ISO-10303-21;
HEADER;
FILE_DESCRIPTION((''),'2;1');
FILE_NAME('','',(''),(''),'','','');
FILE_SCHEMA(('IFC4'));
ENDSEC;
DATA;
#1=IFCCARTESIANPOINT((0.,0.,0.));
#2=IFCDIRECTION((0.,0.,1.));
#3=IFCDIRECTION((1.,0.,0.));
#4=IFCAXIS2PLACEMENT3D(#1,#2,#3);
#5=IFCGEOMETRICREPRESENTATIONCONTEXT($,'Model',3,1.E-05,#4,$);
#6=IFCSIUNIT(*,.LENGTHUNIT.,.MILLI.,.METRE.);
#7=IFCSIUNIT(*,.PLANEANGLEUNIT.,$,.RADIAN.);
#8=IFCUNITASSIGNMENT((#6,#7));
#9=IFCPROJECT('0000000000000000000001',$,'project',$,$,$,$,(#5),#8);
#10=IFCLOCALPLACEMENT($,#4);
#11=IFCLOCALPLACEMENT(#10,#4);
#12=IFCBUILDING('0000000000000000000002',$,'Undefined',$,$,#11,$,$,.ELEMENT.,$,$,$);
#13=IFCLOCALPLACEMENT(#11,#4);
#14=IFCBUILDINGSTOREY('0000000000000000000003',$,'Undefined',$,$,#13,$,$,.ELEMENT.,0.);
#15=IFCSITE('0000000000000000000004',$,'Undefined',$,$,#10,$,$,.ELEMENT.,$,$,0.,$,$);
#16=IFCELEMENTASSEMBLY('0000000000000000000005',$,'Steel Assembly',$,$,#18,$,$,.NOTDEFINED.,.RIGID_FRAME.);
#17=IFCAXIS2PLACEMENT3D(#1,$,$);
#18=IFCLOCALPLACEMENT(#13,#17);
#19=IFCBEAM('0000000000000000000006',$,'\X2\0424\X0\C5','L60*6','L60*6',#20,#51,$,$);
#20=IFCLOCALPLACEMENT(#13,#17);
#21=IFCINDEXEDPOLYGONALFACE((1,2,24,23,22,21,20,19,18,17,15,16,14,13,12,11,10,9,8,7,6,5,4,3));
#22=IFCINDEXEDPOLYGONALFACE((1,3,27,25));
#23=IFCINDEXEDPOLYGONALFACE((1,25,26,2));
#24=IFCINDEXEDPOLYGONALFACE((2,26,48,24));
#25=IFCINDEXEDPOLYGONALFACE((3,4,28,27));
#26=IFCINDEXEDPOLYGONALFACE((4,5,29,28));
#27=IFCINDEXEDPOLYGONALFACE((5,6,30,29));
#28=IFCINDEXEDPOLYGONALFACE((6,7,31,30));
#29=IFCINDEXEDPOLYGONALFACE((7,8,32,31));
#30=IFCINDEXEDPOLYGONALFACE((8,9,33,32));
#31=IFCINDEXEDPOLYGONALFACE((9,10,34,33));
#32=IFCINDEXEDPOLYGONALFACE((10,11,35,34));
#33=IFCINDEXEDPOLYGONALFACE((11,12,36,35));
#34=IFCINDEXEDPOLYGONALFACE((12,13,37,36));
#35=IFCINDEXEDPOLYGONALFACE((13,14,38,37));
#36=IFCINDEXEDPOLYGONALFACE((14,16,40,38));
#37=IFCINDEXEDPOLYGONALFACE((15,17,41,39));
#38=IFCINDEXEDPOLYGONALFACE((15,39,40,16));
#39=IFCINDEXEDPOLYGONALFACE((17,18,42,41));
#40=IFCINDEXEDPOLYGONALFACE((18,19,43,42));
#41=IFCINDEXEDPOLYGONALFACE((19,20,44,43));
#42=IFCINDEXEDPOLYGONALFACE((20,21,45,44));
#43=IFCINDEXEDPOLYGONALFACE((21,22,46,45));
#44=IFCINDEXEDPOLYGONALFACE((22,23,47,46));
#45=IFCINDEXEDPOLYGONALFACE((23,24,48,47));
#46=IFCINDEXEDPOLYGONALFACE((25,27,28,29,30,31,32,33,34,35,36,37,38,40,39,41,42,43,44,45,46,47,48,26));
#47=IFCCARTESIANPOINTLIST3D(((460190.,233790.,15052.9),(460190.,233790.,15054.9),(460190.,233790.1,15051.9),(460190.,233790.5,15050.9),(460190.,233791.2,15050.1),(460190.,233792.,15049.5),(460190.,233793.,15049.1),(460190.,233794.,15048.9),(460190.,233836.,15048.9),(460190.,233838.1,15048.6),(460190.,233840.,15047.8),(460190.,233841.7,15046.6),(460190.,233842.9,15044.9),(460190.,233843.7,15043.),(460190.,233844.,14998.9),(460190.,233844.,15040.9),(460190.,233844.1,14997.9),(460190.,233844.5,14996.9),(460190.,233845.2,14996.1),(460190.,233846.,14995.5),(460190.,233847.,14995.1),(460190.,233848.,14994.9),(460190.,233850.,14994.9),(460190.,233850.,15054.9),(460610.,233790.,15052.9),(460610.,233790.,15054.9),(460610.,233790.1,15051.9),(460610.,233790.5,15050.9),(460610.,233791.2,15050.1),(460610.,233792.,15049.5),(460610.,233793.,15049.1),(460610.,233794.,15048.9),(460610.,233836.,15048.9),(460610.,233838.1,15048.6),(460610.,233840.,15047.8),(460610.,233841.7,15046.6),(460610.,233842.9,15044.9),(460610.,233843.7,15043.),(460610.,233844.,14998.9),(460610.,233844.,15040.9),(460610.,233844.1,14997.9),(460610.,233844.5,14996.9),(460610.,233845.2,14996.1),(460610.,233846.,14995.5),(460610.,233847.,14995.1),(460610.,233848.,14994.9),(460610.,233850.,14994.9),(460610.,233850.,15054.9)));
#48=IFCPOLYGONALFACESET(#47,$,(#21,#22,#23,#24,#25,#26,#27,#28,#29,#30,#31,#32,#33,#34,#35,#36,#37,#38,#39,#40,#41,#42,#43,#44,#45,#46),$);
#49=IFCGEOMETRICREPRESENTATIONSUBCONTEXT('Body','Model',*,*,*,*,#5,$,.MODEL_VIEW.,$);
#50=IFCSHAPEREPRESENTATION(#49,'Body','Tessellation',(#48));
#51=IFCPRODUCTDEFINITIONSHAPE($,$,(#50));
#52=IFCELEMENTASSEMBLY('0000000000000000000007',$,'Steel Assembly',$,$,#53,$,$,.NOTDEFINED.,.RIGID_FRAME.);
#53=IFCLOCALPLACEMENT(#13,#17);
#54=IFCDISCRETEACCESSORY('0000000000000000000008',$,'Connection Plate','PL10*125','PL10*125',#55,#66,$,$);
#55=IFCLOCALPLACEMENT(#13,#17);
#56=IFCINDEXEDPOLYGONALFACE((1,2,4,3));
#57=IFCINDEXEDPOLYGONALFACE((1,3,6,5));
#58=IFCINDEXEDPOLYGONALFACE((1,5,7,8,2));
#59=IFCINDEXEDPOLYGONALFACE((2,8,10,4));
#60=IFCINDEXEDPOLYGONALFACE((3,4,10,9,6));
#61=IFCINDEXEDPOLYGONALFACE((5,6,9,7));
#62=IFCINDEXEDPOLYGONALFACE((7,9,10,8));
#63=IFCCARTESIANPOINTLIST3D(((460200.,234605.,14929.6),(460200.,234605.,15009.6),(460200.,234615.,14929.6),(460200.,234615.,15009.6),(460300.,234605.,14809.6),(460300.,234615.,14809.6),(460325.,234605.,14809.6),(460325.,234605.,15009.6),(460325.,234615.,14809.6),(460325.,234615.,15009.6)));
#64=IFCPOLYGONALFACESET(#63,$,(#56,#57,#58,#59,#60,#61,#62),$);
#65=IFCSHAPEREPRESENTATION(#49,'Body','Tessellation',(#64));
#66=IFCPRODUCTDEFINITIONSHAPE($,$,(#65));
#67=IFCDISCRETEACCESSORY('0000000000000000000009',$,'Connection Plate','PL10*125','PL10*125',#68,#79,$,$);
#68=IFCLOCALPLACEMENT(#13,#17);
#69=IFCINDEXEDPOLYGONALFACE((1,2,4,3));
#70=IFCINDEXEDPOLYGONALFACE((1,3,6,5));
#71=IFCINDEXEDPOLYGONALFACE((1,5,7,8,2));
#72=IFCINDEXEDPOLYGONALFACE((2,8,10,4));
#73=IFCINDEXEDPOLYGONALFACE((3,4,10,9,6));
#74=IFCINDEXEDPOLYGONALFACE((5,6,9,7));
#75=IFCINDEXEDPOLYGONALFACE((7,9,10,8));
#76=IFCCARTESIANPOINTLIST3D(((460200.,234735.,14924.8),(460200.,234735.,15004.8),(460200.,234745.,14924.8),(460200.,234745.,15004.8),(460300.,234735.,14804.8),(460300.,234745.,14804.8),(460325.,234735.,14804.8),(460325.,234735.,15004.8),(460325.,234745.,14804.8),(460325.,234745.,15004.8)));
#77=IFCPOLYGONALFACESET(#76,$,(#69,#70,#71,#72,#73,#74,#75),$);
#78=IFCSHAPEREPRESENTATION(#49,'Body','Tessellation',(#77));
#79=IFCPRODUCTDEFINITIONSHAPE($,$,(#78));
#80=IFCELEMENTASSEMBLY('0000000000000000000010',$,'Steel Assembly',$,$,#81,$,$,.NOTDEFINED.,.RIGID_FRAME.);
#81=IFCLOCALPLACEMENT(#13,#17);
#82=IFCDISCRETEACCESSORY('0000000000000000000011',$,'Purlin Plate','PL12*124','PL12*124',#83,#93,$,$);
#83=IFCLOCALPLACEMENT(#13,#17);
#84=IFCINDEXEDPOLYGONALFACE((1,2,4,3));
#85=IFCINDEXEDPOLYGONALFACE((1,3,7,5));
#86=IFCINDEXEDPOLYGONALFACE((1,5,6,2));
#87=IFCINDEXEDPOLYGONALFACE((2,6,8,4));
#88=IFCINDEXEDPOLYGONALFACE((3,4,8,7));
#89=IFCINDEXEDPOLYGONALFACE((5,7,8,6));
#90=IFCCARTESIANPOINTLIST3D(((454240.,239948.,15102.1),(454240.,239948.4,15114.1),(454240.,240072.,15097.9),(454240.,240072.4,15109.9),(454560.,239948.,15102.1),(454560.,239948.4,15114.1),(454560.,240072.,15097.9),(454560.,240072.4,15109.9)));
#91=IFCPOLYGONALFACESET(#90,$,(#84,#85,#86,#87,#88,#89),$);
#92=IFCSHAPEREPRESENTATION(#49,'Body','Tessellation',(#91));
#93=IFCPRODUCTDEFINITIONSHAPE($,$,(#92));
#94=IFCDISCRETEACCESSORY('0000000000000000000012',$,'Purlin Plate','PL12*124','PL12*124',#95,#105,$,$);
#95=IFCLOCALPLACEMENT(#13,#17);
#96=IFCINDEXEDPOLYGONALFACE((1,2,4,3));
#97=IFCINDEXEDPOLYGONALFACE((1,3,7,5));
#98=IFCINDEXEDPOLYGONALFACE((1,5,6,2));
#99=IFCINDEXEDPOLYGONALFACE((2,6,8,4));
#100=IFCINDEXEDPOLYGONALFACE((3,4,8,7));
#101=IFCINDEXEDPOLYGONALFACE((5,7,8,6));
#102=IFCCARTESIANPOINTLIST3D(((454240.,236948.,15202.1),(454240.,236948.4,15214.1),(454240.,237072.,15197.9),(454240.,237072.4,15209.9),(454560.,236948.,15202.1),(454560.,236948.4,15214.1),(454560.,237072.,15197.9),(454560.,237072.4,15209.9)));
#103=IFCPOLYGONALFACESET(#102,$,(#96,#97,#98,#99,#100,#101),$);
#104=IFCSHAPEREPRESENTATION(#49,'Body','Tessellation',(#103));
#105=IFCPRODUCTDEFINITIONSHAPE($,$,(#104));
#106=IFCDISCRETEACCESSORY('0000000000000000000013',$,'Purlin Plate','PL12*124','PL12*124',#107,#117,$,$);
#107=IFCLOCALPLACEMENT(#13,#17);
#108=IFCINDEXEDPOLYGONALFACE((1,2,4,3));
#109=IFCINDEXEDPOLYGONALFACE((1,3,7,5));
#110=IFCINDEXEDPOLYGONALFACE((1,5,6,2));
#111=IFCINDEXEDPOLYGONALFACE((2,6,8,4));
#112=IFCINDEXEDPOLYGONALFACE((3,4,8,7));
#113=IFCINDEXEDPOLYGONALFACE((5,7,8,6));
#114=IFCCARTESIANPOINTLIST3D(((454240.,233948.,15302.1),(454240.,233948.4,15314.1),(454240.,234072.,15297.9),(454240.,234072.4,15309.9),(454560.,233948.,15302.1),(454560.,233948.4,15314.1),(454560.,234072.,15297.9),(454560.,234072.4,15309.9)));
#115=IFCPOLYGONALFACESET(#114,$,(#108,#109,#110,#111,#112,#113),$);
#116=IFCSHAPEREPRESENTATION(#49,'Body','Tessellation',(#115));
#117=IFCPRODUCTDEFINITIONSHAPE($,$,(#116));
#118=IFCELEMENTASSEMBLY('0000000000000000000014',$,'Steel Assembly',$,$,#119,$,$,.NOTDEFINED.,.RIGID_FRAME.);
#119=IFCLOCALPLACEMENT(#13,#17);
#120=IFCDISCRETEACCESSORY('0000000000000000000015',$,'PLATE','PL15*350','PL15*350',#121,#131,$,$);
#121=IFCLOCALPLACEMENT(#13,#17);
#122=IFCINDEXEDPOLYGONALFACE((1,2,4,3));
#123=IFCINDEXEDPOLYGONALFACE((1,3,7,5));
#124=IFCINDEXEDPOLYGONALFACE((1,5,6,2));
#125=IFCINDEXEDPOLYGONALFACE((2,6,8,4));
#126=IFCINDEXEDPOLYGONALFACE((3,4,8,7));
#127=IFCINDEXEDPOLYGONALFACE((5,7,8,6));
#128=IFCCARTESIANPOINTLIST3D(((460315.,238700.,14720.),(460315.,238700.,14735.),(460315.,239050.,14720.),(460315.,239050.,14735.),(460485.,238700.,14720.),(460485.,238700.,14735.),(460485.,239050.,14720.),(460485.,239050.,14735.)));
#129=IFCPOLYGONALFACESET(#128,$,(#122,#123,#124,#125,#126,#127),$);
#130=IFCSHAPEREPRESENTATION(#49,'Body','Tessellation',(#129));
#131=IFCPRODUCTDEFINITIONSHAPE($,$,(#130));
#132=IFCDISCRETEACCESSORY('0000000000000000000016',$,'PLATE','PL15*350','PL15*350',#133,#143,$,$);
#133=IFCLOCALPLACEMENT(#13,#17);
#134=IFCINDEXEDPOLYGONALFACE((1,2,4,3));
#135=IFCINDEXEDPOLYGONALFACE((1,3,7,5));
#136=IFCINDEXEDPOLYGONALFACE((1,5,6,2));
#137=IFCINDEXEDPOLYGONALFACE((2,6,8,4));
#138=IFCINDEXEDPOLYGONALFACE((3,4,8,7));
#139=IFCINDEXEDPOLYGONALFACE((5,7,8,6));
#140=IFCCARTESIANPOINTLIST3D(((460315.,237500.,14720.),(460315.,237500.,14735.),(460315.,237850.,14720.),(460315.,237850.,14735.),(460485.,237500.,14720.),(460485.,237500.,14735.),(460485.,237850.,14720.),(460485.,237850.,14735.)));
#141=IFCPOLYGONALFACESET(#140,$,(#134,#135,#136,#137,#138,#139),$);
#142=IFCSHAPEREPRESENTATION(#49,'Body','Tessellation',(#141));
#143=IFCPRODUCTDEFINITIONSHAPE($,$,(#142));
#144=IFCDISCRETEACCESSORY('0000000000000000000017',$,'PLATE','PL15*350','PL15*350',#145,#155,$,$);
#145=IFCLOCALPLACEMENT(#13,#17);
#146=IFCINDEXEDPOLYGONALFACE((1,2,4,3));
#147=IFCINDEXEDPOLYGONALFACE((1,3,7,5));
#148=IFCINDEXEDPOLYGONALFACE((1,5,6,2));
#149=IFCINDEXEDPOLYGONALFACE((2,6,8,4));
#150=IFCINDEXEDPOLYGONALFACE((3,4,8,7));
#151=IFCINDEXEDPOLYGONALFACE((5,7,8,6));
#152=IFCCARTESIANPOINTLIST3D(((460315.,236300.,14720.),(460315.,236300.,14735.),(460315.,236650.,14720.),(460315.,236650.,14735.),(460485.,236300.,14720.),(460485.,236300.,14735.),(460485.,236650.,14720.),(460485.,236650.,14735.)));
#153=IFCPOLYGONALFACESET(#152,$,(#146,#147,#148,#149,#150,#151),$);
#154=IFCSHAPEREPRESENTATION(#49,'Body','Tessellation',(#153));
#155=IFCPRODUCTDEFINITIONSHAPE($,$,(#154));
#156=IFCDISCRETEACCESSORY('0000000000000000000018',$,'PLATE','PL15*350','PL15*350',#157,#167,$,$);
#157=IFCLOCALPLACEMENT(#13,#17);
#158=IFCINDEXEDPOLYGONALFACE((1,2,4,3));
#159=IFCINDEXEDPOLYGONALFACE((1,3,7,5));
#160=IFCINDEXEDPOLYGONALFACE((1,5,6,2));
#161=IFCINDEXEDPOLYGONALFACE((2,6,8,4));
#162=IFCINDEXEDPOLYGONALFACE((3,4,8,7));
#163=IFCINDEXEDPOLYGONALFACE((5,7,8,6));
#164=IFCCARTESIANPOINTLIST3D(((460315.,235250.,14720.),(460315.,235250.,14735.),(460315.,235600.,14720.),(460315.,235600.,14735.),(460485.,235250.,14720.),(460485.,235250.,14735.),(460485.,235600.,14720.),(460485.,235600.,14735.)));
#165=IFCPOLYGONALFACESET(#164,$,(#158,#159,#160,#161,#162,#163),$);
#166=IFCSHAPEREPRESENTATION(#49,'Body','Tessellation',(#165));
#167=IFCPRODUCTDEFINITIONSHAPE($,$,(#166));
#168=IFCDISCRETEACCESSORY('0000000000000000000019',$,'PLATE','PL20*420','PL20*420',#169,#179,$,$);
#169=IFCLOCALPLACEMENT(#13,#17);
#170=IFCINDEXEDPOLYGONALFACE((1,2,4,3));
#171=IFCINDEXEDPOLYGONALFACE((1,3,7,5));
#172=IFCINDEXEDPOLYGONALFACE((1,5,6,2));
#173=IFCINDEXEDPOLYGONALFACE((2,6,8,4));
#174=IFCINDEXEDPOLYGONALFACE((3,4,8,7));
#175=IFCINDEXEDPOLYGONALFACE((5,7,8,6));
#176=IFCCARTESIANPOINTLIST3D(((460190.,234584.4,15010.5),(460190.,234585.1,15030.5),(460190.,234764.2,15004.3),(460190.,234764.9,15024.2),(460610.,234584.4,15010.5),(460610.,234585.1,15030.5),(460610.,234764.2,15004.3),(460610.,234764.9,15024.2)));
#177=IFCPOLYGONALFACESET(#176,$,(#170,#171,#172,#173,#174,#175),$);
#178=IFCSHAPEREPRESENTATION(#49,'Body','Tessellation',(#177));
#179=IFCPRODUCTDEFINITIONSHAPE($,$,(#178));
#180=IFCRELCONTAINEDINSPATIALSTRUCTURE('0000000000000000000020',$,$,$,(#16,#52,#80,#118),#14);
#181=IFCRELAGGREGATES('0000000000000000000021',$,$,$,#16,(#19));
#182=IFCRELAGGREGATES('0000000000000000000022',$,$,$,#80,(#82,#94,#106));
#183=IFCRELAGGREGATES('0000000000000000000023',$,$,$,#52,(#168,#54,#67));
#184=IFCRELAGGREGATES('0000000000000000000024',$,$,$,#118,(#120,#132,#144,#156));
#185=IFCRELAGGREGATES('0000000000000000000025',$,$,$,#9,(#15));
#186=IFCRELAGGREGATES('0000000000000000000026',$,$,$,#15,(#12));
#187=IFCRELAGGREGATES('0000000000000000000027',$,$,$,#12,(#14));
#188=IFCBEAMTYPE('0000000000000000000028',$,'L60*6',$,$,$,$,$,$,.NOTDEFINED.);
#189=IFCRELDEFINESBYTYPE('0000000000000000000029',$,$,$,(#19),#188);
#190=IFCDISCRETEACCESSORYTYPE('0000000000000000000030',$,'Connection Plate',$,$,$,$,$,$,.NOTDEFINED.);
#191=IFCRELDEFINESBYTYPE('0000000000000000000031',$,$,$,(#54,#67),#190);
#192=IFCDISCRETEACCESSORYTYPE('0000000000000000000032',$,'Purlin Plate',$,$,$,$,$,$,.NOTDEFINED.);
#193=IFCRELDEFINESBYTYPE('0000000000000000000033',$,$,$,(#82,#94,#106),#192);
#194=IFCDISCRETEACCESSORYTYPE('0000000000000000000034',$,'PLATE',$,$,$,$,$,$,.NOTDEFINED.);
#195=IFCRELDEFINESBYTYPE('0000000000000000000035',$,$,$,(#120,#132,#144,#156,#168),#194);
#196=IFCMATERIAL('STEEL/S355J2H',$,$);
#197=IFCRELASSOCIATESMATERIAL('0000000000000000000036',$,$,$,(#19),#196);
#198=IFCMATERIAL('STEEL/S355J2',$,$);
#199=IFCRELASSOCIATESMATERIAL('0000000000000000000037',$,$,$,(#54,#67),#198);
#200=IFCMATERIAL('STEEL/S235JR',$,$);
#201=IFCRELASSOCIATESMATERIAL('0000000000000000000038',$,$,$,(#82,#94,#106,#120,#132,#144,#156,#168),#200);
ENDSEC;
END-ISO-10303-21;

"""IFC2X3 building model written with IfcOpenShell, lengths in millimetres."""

from ifc_helpers import new_model, si_unit, frame, origin_with_axes, origin_2d_with_axis, place, context, subcontext, project, spatial, polyline, l_section, outline, extrude, material, type_object, element, aggregate, save


model = new_model("IFC2X3")

# Units and contexts
model_context = context("Model", 3, precision=1e-05, world=origin_with_axes())
body_context = subcontext(model_context, "Body", "Model", "MODEL_VIEW")
ifc_project = project(units=[si_unit("LENGTHUNIT", "METRE", prefix="MILLI"), si_unit("PLANEANGLEUNIT", "RADIAN")], contexts=[model_context])

# Site, building, storey
site_placement = place(None, origin_with_axes())
site = spatial("IfcSite", under=ifc_project, at=site_placement, Name="Undefined", CompositionType="ELEMENT", RefElevation=0.0)
building_placement = place(site_placement, origin_with_axes())
building = spatial("IfcBuilding", under=site, at=building_placement, Name="Undefined", CompositionType="ELEMENT")
storey_placement = place(building_placement, origin_with_axes())
storey = spatial("IfcBuildingStorey", under=building, at=storey_placement, Name="Undefined", CompositionType="ELEMENT", Elevation=0.0)

# Element assembly, beam
ifc_material_1 = material(Name="STEEL/S355J2H")
beam_type_1 = type_object("IfcBeamType", Name="L60*6", PredefinedType="NOTDEFINED")
assembly_1_placement = place(storey_placement, origin_with_axes())
assembly_1 = element("IfcElementAssembly", 1, at=assembly_1_placement, inside=storey, Name="Steel Assembly", AssemblyPlace="NOTDEFINED", PredefinedType="RIGID_FRAME")
beam_1_placement = place(assembly_1_placement, frame((460190.0, 233820.0, 15024.9), z_axis=(0.0, -1.0, 0.0), x_axis=(1.0, 0.0, 0.0)))
beam_1 = element("IfcBeam", 2, at=beam_1_placement, type_object=beam_type_1, material=ifc_material_1, Name="ФC5", Description="L60*6", ObjectType="L60*6", context=body_context, shape_type="SweptSolid", body=[
    extrude(l_section(Depth=60.0, Width=60.0, Thickness=6.0, FilletRadius=8.0, EdgeRadius=4.0, at=origin_2d_with_axis()), frame((420.0, 0.0, 0.0), z_axis=(-1.0, 0.0, 0.0), x_axis=(0.0, -1.0, 0.0)), (0.0, 0.0, 1.0), 420.0),
])
aggregate(assembly_1, [beam_1])

# Element assemblies, discrete accessories
assembly_2_placement = place(storey_placement, origin_with_axes())
assembly_2 = element("IfcElementAssembly", 3, at=assembly_2_placement, inside=storey, Name="Steel Assembly", AssemblyPlace="NOTDEFINED", PredefinedType="RIGID_FRAME")
ifc_material_2 = material(Name="STEEL/S355J2")
discrete_accessory_type_1 = type_object("IfcDiscreteAccessoryType", Name="Connection Plate")
discrete_accessory_1_placement = place(assembly_2_placement, frame((460200.0, 234610.0, 15009.6), z_axis=(0.0, 1.0, 0.0), x_axis=(1.0, 0.0, 0.0)))
discrete_accessory_1 = element("IfcDiscreteAccessory", 4, at=discrete_accessory_1_placement, type_object=discrete_accessory_type_1, material=ifc_material_2, Name="Connection Plate", Description="PL10*125", ObjectType="PL10*125", context=body_context, shape_type="SweptSolid", body=[
    extrude(outline(polyline([(0.0, 0.0), (125.0, 0.0), (125.0, 200.0), (100.0, 200.0), (0.0, 80.0), (0.0, 0.0)])), frame((0.0, 0.0, -5.0), z_axis=(0.0, 0.0, 1.0), x_axis=(1.0, 0.0, 0.0)), (0.0, 0.0, 1.0), 10.0),
])
discrete_accessory_2_placement = place(assembly_2_placement, frame((460200.0, 234740.0, 15004.8), z_axis=(0.0, 1.0, 0.0), x_axis=(1.0, 0.0, 0.0)))
discrete_accessory_2 = element("IfcDiscreteAccessory", 5, at=discrete_accessory_2_placement, type_object=discrete_accessory_type_1, material=ifc_material_2, Name="Connection Plate", Description="PL10*125", ObjectType="PL10*125", context=body_context, shape_type="SweptSolid", body=[
    extrude(outline(polyline([(0.0, 0.0), (125.0, 0.0), (125.0, 200.0), (100.0, 200.0), (0.0, 80.0), (0.0, 0.0)])), frame((0.0, 0.0, -5.0), z_axis=(0.0, 0.0, 1.0), x_axis=(1.0, 0.0, 0.0)), (0.0, 0.0, 1.0), 10.0),
])
assembly_3_placement = place(storey_placement, origin_with_axes())
assembly_3 = element("IfcElementAssembly", 6, at=assembly_3_placement, inside=storey, Name="Steel Assembly", AssemblyPlace="NOTDEFINED", PredefinedType="RIGID_FRAME")
ifc_material_3 = material(Name="STEEL/S235JR")
discrete_accessory_type_2 = type_object("IfcDiscreteAccessoryType", Name="Purlin Plate")
discrete_accessory_3_placement = place(assembly_3_placement, frame((454560.0, 240072.2, 15103.9), z_axis=(0.0, -0.033315, -0.999445), x_axis=(0.0, -0.999445, 0.033315)))
discrete_accessory_3 = element("IfcDiscreteAccessory", 7, at=discrete_accessory_3_placement, type_object=discrete_accessory_type_2, material=ifc_material_3, Name="Purlin Plate", Description="PL12*124", ObjectType="PL12*124", context=body_context, shape_type="SweptSolid", body=[
    extrude(outline(polyline([(0.0, 0.0), (124.0, 0.0), (124.0, 320.0), (0.0, 320.0), (0.0, 0.0)])), frame((0.0, 0.0, -6.0), z_axis=(0.0, 0.0, 1.0), x_axis=(1.0, 0.0, 0.0)), (0.0, 0.0, 1.0), 12.0),
])
discrete_accessory_4_placement = place(assembly_3_placement, frame((454560.0, 237072.2, 15203.9), z_axis=(0.0, -0.033315, -0.999445), x_axis=(0.0, -0.999445, 0.033315)))
discrete_accessory_4 = element("IfcDiscreteAccessory", 8, at=discrete_accessory_4_placement, type_object=discrete_accessory_type_2, material=ifc_material_3, Name="Purlin Plate", Description="PL12*124", ObjectType="PL12*124", context=body_context, shape_type="SweptSolid", body=[
    extrude(outline(polyline([(0.0, 0.0), (124.0, 0.0), (124.0, 320.0), (0.0, 320.0), (0.0, 0.0)])), frame((0.0, 0.0, -6.0), z_axis=(0.0, 0.0, 1.0), x_axis=(1.0, 0.0, 0.0)), (0.0, 0.0, 1.0), 12.0),
])
discrete_accessory_5_placement = place(assembly_3_placement, frame((454560.0, 234072.2, 15303.9), z_axis=(0.0, -0.033315, -0.999445), x_axis=(0.0, -0.999445, 0.033315)))
discrete_accessory_5 = element("IfcDiscreteAccessory", 9, at=discrete_accessory_5_placement, type_object=discrete_accessory_type_2, material=ifc_material_3, Name="Purlin Plate", Description="PL12*124", ObjectType="PL12*124", context=body_context, shape_type="SweptSolid", body=[
    extrude(outline(polyline([(0.0, 0.0), (124.0, 0.0), (124.0, 320.0), (0.0, 320.0), (0.0, 0.0)])), frame((0.0, 0.0, -6.0), z_axis=(0.0, 0.0, 1.0), x_axis=(1.0, 0.0, 0.0)), (0.0, 0.0, 1.0), 12.0),
])
aggregate(assembly_3, [discrete_accessory_3, discrete_accessory_4, discrete_accessory_5])
assembly_4_placement = place(storey_placement, origin_with_axes())
assembly_4 = element("IfcElementAssembly", 10, at=assembly_4_placement, inside=storey, Name="Steel Assembly", AssemblyPlace="NOTDEFINED", PredefinedType="RIGID_FRAME")
discrete_accessory_type_3 = type_object("IfcDiscreteAccessoryType", Name="PLATE")
discrete_accessory_6_placement = place(assembly_4_placement, frame((460485.0, 238875.0, 14727.5), z_axis=(0.0, 0.0, 1.0), x_axis=(-1.0, 0.0, 0.0)))
discrete_accessory_6 = element("IfcDiscreteAccessory", 11, at=discrete_accessory_6_placement, type_object=discrete_accessory_type_3, material=ifc_material_3, Name="PLATE", Description="PL15*350", ObjectType="PL15*350", context=body_context, shape_type="SweptSolid", body=[
    extrude(outline(polyline([(170.0, -175.0), (0.0, -175.0), (0.0, 175.0), (170.0, 175.0), (170.0, -175.0)])), frame((0.0, 0.0, -7.5), z_axis=(0.0, 0.0, 1.0), x_axis=(1.0, 0.0, 0.0)), (0.0, 0.0, 1.0), 15.0),
])
discrete_accessory_7_placement = place(assembly_4_placement, frame((460485.0, 237675.0, 14727.5), z_axis=(0.0, 0.0, 1.0), x_axis=(-1.0, 0.0, 0.0)))
discrete_accessory_7 = element("IfcDiscreteAccessory", 12, at=discrete_accessory_7_placement, type_object=discrete_accessory_type_3, material=ifc_material_3, Name="PLATE", Description="PL15*350", ObjectType="PL15*350", context=body_context, shape_type="SweptSolid", body=[
    extrude(outline(polyline([(170.0, -175.0), (0.0, -175.0), (0.0, 175.0), (170.0, 175.0), (170.0, -175.0)])), frame((0.0, 0.0, -7.5), z_axis=(0.0, 0.0, 1.0), x_axis=(1.0, 0.0, 0.0)), (0.0, 0.0, 1.0), 15.0),
])
discrete_accessory_8_placement = place(assembly_4_placement, frame((460485.0, 236475.0, 14727.5), z_axis=(0.0, 0.0, 1.0), x_axis=(-1.0, 0.0, 0.0)))
discrete_accessory_8 = element("IfcDiscreteAccessory", 13, at=discrete_accessory_8_placement, type_object=discrete_accessory_type_3, material=ifc_material_3, Name="PLATE", Description="PL15*350", ObjectType="PL15*350", context=body_context, shape_type="SweptSolid", body=[
    extrude(outline(polyline([(170.0, -175.0), (0.0, -175.0), (0.0, 175.0), (170.0, 175.0), (170.0, -175.0)])), frame((0.0, 0.0, -7.5), z_axis=(0.0, 0.0, 1.0), x_axis=(1.0, 0.0, 0.0)), (0.0, 0.0, 1.0), 15.0),
])
discrete_accessory_9_placement = place(assembly_4_placement, frame((460485.0, 235425.0, 14727.5), z_axis=(0.0, 0.0, 1.0), x_axis=(-1.0, 0.0, 0.0)))
discrete_accessory_9 = element("IfcDiscreteAccessory", 14, at=discrete_accessory_9_placement, type_object=discrete_accessory_type_3, material=ifc_material_3, Name="PLATE", Description="PL15*350", ObjectType="PL15*350", context=body_context, shape_type="SweptSolid", body=[
    extrude(outline(polyline([(170.0, -175.0), (0.0, -175.0), (0.0, 175.0), (170.0, 175.0), (170.0, -175.0)])), frame((0.0, 0.0, -7.5), z_axis=(0.0, 0.0, 1.0), x_axis=(1.0, 0.0, 0.0)), (0.0, 0.0, 1.0), 15.0),
])

# Discrete accessory
discrete_accessory_10_placement = place(assembly_2_placement, frame((460400.0, 234584.7, 15020.5), z_axis=(0.0, -0.034899, -0.999391), x_axis=(0.0, 0.999391, -0.034899)))
discrete_accessory_10 = element("IfcDiscreteAccessory", 15, at=discrete_accessory_10_placement, type_object=discrete_accessory_type_3, material=ifc_material_3, Name="PLATE", Description="PL20*420", ObjectType="PL20*420", context=body_context, shape_type="SweptSolid", body=[
    extrude(outline(polyline([(0.0, 210.0), (180.0, 210.0), (180.0, -210.0), (0.0, -210.0), (0.0, 210.0)])), frame((0.0, 0.0, -10.0), z_axis=(0.0, 0.0, 1.0), x_axis=(1.0, 0.0, 0.0)), (0.0, 0.0, 1.0), 20.0),
])
aggregate(assembly_2, [discrete_accessory_10, discrete_accessory_1, discrete_accessory_2])
aggregate(assembly_4, [discrete_accessory_6, discrete_accessory_7, discrete_accessory_8, discrete_accessory_9])

save(model, "model.ifc")
